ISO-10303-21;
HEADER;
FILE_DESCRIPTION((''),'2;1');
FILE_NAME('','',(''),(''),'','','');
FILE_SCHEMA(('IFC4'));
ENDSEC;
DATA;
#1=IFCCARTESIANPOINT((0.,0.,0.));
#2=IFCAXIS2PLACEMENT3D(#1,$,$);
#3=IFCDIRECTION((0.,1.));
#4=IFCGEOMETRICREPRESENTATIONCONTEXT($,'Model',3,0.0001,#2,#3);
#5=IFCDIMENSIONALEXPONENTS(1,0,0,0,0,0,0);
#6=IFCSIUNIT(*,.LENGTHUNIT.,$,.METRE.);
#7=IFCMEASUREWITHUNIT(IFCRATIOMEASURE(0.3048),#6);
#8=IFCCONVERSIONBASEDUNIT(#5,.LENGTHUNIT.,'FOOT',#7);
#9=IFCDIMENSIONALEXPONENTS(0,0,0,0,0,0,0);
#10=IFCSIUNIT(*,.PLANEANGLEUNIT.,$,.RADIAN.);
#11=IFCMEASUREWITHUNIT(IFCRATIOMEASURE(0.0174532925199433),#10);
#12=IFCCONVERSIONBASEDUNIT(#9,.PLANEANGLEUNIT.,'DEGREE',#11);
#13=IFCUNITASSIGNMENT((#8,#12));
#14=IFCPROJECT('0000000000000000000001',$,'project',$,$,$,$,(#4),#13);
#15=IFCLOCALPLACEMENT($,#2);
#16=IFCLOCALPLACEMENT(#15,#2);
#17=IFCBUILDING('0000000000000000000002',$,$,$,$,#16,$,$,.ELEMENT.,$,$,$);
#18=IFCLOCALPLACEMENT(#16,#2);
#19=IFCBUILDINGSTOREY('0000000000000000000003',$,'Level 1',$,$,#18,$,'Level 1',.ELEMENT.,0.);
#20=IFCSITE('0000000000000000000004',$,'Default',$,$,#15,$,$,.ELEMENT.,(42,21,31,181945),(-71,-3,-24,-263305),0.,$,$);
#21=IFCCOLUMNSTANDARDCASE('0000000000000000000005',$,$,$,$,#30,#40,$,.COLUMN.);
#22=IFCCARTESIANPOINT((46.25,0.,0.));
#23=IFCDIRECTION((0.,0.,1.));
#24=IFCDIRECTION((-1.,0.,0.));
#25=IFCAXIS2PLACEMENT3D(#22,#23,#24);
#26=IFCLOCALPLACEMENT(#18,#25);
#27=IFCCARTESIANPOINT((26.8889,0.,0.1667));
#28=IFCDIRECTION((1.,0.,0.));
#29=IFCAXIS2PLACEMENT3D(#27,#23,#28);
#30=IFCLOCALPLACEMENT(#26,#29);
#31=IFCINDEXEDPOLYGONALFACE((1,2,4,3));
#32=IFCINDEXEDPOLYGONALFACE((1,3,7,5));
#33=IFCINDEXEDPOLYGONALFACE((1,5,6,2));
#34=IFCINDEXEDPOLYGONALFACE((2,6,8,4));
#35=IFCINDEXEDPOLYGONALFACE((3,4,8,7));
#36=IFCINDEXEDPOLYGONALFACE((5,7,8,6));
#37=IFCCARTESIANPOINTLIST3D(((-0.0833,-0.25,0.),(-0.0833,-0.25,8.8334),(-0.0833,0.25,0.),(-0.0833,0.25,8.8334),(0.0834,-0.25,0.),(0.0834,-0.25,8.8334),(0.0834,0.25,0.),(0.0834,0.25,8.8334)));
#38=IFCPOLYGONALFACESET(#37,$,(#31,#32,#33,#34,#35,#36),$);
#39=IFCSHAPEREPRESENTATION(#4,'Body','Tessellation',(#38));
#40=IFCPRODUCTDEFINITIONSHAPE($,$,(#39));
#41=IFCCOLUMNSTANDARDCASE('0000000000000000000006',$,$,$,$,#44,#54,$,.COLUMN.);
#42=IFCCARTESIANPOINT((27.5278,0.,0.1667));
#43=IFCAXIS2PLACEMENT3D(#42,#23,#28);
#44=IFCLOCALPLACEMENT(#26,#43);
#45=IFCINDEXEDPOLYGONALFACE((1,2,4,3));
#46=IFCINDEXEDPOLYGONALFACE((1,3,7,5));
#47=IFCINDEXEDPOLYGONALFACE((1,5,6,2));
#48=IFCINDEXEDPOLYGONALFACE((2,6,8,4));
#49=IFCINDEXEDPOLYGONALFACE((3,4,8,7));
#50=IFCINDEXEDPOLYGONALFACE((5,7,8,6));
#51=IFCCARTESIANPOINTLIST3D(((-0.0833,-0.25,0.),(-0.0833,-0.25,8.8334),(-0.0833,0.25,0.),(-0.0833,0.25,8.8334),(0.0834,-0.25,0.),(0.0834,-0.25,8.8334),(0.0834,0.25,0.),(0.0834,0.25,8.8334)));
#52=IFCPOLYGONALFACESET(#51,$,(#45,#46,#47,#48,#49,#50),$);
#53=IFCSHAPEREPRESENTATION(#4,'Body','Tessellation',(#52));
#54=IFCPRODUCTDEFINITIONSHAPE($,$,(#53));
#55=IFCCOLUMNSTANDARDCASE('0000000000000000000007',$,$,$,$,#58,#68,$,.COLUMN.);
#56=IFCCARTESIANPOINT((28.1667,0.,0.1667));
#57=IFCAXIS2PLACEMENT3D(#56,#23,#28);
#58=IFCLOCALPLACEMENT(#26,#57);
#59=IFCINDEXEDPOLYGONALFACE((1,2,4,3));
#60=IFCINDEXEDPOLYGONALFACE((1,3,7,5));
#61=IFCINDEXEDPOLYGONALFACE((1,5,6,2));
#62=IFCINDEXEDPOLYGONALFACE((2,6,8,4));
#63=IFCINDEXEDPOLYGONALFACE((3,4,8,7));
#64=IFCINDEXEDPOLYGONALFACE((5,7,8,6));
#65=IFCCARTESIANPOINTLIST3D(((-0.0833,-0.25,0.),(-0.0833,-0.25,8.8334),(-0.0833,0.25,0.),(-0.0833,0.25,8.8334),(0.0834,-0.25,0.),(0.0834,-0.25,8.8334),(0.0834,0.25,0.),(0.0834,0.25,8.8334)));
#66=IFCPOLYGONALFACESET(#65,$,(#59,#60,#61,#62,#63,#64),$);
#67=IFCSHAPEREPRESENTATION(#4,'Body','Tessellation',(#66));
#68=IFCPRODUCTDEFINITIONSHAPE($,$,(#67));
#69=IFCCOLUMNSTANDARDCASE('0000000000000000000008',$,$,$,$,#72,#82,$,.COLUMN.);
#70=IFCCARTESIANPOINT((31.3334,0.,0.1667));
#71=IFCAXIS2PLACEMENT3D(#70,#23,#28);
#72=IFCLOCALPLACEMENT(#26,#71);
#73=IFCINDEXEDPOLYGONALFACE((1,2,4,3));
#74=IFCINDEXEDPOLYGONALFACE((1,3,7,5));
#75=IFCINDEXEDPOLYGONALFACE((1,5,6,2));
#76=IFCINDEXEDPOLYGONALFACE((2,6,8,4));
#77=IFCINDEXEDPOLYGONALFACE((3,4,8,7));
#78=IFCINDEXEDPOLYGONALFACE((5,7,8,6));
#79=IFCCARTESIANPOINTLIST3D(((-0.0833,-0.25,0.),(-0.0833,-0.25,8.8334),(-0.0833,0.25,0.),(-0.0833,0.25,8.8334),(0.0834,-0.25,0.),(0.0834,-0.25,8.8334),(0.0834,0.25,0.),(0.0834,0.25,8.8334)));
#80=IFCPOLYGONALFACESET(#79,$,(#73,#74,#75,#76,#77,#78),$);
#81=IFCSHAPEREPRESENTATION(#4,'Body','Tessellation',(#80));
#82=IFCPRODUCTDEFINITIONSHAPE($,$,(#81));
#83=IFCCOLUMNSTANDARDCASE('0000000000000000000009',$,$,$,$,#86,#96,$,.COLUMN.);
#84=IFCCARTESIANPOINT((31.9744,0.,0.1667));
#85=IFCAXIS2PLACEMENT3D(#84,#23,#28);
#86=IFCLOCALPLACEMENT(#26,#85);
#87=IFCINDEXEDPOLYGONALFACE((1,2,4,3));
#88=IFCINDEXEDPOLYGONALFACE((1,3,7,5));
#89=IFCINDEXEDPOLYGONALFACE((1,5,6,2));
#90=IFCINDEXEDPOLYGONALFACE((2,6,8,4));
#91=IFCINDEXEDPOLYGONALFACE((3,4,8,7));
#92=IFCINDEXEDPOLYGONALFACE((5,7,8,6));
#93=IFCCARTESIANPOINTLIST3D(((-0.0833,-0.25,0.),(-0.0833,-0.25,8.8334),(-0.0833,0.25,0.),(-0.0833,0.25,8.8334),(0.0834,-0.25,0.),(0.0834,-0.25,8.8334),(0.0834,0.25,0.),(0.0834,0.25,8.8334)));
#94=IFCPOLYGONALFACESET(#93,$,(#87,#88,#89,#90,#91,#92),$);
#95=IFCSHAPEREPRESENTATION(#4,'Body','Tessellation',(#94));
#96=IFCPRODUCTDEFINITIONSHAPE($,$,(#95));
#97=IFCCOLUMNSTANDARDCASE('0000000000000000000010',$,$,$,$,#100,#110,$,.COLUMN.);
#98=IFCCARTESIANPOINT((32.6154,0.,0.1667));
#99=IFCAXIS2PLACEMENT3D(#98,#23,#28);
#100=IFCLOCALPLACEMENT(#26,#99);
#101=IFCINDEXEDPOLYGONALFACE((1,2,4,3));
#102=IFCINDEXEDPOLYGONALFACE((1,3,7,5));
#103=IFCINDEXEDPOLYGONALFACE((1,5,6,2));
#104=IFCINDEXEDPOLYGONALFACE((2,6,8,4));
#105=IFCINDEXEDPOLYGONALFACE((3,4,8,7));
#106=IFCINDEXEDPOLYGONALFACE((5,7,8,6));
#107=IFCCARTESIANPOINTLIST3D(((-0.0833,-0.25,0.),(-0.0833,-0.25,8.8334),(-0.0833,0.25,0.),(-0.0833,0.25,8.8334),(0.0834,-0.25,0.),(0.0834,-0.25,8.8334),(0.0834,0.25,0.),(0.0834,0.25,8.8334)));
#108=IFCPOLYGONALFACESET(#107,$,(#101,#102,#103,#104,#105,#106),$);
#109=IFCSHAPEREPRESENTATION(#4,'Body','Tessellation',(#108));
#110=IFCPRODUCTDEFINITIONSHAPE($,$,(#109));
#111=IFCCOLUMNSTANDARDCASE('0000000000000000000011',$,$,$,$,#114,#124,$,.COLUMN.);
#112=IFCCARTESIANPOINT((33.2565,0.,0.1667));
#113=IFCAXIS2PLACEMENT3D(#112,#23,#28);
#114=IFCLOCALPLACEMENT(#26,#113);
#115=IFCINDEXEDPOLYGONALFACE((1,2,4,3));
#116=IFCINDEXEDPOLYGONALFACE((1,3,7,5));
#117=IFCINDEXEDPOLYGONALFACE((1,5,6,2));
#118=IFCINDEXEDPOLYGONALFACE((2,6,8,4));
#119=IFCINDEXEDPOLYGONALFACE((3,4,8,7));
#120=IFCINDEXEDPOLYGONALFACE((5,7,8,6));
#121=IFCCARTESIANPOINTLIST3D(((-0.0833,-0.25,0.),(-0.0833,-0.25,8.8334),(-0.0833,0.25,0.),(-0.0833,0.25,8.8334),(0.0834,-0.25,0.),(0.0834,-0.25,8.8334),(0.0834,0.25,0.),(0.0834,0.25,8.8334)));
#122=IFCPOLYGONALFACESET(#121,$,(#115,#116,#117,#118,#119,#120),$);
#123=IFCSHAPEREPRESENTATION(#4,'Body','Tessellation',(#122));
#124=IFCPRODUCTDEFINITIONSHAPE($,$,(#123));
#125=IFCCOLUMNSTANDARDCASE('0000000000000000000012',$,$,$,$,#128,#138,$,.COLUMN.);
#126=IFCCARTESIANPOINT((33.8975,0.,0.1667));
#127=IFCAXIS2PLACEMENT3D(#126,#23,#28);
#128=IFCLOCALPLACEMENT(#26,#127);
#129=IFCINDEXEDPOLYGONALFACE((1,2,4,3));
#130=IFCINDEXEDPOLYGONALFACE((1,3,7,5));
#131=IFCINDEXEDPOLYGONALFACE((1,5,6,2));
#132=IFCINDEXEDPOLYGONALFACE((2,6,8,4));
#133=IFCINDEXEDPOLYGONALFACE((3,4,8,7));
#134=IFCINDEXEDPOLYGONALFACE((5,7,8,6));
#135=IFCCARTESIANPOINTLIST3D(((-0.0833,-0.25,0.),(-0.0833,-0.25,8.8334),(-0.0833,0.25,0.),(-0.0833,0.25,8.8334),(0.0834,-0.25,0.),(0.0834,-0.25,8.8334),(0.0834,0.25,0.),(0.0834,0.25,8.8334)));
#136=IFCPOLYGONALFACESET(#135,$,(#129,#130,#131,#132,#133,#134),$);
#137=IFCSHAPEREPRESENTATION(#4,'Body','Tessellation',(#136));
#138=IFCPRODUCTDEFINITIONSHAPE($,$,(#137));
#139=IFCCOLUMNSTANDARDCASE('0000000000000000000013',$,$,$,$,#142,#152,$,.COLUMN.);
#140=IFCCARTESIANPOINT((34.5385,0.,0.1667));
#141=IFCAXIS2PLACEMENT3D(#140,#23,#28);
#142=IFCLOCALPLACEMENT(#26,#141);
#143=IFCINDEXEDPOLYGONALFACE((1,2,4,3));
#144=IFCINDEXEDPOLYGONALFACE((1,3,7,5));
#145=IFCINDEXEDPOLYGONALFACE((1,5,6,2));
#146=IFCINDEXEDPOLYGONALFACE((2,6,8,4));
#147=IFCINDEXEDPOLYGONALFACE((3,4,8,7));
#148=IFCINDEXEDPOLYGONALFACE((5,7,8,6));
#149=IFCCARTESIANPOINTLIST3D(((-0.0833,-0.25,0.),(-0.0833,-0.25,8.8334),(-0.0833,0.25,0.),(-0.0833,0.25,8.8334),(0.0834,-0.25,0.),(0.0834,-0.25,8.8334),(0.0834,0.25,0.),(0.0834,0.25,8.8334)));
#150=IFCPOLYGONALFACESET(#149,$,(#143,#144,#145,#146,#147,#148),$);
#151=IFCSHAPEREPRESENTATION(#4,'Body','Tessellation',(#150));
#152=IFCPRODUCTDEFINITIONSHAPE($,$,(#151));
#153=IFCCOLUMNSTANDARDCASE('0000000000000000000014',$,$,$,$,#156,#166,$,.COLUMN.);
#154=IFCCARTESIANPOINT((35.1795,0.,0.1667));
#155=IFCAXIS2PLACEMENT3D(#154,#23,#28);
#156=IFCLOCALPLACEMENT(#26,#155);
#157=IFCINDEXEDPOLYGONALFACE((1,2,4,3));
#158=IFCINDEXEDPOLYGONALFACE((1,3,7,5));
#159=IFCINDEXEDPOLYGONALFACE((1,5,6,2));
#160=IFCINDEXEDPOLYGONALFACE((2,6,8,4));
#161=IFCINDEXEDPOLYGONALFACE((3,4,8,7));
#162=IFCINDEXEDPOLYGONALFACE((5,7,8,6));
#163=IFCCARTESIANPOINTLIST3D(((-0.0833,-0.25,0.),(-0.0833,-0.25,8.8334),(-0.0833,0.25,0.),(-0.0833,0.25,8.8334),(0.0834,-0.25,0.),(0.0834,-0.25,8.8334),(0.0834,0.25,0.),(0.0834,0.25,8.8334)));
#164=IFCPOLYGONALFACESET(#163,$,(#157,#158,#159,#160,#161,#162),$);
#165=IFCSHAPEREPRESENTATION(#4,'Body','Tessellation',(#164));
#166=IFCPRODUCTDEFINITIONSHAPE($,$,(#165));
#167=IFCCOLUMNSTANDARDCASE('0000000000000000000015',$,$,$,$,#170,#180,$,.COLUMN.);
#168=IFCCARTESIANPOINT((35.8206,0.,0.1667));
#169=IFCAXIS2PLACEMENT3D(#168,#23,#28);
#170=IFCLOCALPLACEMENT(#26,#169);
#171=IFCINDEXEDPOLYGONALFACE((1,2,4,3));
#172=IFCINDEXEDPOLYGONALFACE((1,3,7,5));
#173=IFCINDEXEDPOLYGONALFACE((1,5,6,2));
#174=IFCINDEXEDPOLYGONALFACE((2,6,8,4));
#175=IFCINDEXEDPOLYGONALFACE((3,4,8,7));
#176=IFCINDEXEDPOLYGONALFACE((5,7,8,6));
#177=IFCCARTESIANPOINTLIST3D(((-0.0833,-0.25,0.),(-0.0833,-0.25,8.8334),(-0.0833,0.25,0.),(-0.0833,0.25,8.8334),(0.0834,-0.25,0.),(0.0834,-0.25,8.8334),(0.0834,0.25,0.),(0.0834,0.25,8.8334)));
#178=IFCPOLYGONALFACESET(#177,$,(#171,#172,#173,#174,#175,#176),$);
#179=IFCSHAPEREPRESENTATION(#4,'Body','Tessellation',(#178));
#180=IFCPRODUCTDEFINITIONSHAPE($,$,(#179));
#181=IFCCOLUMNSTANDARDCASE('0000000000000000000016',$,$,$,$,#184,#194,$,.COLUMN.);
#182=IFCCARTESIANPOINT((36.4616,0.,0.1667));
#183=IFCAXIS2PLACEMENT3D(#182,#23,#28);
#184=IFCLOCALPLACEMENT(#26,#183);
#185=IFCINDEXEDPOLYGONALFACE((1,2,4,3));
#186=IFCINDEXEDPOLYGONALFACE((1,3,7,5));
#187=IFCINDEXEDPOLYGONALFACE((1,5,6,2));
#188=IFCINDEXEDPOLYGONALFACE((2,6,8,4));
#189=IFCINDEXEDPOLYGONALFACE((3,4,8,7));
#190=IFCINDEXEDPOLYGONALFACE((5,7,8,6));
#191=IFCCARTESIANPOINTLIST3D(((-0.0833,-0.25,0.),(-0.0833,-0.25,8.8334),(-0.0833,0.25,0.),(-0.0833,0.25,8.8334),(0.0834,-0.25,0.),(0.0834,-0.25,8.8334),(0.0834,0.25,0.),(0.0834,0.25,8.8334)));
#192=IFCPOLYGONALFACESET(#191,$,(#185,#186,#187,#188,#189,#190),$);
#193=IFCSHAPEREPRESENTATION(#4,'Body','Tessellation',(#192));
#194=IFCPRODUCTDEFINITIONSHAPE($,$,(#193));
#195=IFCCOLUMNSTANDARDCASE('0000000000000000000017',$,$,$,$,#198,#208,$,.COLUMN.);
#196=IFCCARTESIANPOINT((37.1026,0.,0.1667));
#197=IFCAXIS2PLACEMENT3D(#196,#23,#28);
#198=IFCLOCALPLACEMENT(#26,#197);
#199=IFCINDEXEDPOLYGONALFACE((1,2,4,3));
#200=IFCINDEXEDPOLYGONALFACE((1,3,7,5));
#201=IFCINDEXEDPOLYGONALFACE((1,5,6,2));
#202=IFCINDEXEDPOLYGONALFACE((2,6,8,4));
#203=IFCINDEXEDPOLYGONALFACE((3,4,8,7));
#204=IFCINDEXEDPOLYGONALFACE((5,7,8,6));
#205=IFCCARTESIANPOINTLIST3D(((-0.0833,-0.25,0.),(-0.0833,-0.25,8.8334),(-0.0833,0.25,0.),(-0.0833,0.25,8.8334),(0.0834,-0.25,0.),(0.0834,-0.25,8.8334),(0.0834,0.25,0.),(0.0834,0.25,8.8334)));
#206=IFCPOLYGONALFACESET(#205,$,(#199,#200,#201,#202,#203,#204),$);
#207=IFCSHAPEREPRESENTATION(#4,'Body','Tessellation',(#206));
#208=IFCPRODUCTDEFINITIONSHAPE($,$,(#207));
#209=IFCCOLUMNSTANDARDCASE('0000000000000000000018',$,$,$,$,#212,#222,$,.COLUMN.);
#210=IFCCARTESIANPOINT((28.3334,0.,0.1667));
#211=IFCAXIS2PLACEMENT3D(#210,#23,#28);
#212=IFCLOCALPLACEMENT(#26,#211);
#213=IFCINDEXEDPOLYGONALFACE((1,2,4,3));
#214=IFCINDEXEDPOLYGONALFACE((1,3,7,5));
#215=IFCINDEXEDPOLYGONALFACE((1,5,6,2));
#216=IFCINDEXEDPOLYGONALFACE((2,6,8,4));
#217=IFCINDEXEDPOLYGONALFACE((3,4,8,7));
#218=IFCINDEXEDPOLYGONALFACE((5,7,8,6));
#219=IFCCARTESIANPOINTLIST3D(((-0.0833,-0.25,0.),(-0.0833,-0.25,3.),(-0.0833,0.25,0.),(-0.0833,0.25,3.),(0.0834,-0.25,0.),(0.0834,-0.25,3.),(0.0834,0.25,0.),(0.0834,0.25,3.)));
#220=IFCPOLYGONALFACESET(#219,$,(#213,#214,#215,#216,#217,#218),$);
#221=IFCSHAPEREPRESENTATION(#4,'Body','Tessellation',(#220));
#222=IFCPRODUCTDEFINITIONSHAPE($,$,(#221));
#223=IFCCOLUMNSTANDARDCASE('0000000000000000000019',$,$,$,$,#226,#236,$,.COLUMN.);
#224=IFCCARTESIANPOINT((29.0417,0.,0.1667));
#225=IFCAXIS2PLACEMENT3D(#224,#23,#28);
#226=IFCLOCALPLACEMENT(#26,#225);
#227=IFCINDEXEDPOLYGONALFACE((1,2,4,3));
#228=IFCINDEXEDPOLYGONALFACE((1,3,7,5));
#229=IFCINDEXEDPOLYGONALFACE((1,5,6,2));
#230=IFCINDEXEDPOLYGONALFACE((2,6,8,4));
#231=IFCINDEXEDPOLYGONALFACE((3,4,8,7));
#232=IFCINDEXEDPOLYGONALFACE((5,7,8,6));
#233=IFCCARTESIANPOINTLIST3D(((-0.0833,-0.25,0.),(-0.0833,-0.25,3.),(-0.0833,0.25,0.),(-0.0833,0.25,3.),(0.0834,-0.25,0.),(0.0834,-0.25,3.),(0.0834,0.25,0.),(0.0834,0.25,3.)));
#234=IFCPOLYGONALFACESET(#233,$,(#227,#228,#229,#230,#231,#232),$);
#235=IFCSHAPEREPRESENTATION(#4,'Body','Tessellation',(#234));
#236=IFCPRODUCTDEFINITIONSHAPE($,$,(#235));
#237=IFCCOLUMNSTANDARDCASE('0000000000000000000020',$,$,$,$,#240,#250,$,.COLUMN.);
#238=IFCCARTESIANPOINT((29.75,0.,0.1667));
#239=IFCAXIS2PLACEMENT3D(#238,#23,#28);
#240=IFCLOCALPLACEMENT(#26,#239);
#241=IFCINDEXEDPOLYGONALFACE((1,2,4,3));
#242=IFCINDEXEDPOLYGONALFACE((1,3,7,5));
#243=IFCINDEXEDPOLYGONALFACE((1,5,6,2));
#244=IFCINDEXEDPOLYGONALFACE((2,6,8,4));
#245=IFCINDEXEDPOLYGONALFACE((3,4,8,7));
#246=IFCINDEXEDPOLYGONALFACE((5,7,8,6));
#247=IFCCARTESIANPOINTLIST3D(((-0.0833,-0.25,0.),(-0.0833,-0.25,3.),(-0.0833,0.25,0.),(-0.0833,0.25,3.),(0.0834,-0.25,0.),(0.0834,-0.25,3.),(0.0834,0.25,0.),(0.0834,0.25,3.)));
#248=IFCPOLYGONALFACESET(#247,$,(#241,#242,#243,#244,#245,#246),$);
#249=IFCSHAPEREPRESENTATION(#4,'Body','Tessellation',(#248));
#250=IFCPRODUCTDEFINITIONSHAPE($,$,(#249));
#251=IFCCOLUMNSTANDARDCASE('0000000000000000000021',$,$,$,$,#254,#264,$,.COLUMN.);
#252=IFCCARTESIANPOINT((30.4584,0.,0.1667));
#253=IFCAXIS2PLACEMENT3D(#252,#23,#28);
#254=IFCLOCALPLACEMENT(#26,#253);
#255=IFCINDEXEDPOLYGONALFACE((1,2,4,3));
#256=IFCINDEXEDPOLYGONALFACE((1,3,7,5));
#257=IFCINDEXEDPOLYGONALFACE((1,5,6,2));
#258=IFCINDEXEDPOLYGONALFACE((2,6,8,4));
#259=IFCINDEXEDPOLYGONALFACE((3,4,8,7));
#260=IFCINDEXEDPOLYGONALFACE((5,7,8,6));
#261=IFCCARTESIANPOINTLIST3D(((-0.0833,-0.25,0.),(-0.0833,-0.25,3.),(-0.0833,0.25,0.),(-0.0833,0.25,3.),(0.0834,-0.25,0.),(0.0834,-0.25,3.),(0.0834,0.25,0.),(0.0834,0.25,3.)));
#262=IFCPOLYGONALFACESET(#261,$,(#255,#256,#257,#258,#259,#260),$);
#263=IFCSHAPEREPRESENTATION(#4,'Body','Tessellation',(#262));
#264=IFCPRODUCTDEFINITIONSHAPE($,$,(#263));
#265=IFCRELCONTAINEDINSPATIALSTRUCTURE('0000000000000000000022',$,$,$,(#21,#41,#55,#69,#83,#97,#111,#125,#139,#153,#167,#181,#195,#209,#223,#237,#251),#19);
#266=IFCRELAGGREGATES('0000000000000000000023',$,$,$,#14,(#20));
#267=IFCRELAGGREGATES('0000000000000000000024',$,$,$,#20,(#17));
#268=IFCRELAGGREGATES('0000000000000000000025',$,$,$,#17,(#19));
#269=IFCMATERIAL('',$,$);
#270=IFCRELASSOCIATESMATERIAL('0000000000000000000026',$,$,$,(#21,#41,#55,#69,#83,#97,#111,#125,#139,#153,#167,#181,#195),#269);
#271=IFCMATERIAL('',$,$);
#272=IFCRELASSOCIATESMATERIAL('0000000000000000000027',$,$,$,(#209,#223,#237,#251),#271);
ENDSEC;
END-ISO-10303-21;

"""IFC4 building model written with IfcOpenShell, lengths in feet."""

from ifc_helpers import new_model, entity, si_unit, converted_unit, direction, frame, origin, place, context, project, spatial, rectangle, extrude, material, element, save


model = new_model("IFC4")

# Units and contexts
model_context = context("Model", 3, precision=0.0001, world=origin(), true_north=direction((0.0, 1.0)))
ifc_project = project(units=[converted_unit("LENGTHUNIT", "FOOT", entity("IfcRatioMeasure", 0.3048), si_unit("LENGTHUNIT", "METRE"), dimensions=[1, 0, 0, 0, 0, 0, 0]), converted_unit("PLANEANGLEUNIT", "DEGREE", entity("IfcRatioMeasure", 0.0174532925199433), si_unit("PLANEANGLEUNIT", "RADIAN"), dimensions=[0, 0, 0, 0, 0, 0, 0])], contexts=[model_context])

# Site, building, storey
site_placement = place(None, origin())
site = spatial("IfcSite", under=ifc_project, at=site_placement, Name="Default", CompositionType="ELEMENT", RefLatitude=(42, 21, 31, 181945), RefLongitude=(-71, -3, -24, -263305), RefElevation=0.0)
building_placement = place(site_placement, origin())
building = spatial("IfcBuilding", under=site, at=building_placement, CompositionType="ELEMENT")
storey_placement = place(building_placement, origin())
storey = spatial("IfcBuildingStorey", under=building, at=storey_placement, Name="Level 1", LongName="Level 1", CompositionType="ELEMENT", Elevation=0.0)

# Columns
ifc_material_1 = material(Name="")
placement_1 = place(storey_placement, frame((46.25, 0.0, 0.0), z_axis=(0.0, 0.0, 1.0), x_axis=(-1.0, 0.0, 0.0)))
for number, where, z_axis, x_axis in (
    (1, (26.8889, 0.0, 0.1667), (0.0, 0.0, 1.0), (1.0, 0.0, 0.0)),
    (2, (27.5278, 0.0, 0.1667), (0.0, 0.0, 1.0), (1.0, 0.0, 0.0)),
    (3, (28.1667, 0.0, 0.1667), (0.0, 0.0, 1.0), (1.0, 0.0, 0.0)),
    (4, (31.3334, 0.0, 0.1667), (0.0, 0.0, 1.0), (1.0, 0.0, 0.0)),
    (5, (31.9744, 0.0, 0.1667), (0.0, 0.0, 1.0), (1.0, 0.0, 0.0)),
    (6, (32.6154, 0.0, 0.1667), (0.0, 0.0, 1.0), (1.0, 0.0, 0.0)),
    (7, (33.2565, 0.0, 0.1667), (0.0, 0.0, 1.0), (1.0, 0.0, 0.0)),
    (8, (33.8975, 0.0, 0.1667), (0.0, 0.0, 1.0), (1.0, 0.0, 0.0)),
    (9, (34.5385, 0.0, 0.1667), (0.0, 0.0, 1.0), (1.0, 0.0, 0.0)),
    (10, (35.1795, 0.0, 0.1667), (0.0, 0.0, 1.0), (1.0, 0.0, 0.0)),
    (11, (35.8206, 0.0, 0.1667), (0.0, 0.0, 1.0), (1.0, 0.0, 0.0)),
    (12, (36.4616, 0.0, 0.1667), (0.0, 0.0, 1.0), (1.0, 0.0, 0.0)),
    (13, (37.1026, 0.0, 0.1667), (0.0, 0.0, 1.0), (1.0, 0.0, 0.0)),
):
    element("IfcColumnStandardCase", number, at=place(placement_1, frame(where, z_axis=z_axis, x_axis=x_axis)), inside=storey, material=ifc_material_1, PredefinedType="COLUMN", context=model_context, shape_type="SweptSolid", body=[
        extrude(rectangle(XDim=0.1667, YDim=0.5), origin(), (0.0, 0.0, 1.0), 8.8334),
    ])
ifc_material_2 = material(Name="")
for number, where, z_axis, x_axis in (
    (14, (28.3334, 0.0, 0.1667), (0.0, 0.0, 1.0), (1.0, 0.0, 0.0)),
    (15, (29.0417, 0.0, 0.1667), (0.0, 0.0, 1.0), (1.0, 0.0, 0.0)),
    (16, (29.75, 0.0, 0.1667), (0.0, 0.0, 1.0), (1.0, 0.0, 0.0)),
    (17, (30.4584, 0.0, 0.1667), (0.0, 0.0, 1.0), (1.0, 0.0, 0.0)),
):
    element("IfcColumnStandardCase", number, at=place(placement_1, frame(where, z_axis=z_axis, x_axis=x_axis)), inside=storey, material=ifc_material_2, PredefinedType="COLUMN", context=model_context, shape_type="SweptSolid", body=[
        extrude(rectangle(XDim=0.1667, YDim=0.5), origin(), (0.0, 0.0, 1.0), 3.0),
    ])

save(model, "model.ifc")
